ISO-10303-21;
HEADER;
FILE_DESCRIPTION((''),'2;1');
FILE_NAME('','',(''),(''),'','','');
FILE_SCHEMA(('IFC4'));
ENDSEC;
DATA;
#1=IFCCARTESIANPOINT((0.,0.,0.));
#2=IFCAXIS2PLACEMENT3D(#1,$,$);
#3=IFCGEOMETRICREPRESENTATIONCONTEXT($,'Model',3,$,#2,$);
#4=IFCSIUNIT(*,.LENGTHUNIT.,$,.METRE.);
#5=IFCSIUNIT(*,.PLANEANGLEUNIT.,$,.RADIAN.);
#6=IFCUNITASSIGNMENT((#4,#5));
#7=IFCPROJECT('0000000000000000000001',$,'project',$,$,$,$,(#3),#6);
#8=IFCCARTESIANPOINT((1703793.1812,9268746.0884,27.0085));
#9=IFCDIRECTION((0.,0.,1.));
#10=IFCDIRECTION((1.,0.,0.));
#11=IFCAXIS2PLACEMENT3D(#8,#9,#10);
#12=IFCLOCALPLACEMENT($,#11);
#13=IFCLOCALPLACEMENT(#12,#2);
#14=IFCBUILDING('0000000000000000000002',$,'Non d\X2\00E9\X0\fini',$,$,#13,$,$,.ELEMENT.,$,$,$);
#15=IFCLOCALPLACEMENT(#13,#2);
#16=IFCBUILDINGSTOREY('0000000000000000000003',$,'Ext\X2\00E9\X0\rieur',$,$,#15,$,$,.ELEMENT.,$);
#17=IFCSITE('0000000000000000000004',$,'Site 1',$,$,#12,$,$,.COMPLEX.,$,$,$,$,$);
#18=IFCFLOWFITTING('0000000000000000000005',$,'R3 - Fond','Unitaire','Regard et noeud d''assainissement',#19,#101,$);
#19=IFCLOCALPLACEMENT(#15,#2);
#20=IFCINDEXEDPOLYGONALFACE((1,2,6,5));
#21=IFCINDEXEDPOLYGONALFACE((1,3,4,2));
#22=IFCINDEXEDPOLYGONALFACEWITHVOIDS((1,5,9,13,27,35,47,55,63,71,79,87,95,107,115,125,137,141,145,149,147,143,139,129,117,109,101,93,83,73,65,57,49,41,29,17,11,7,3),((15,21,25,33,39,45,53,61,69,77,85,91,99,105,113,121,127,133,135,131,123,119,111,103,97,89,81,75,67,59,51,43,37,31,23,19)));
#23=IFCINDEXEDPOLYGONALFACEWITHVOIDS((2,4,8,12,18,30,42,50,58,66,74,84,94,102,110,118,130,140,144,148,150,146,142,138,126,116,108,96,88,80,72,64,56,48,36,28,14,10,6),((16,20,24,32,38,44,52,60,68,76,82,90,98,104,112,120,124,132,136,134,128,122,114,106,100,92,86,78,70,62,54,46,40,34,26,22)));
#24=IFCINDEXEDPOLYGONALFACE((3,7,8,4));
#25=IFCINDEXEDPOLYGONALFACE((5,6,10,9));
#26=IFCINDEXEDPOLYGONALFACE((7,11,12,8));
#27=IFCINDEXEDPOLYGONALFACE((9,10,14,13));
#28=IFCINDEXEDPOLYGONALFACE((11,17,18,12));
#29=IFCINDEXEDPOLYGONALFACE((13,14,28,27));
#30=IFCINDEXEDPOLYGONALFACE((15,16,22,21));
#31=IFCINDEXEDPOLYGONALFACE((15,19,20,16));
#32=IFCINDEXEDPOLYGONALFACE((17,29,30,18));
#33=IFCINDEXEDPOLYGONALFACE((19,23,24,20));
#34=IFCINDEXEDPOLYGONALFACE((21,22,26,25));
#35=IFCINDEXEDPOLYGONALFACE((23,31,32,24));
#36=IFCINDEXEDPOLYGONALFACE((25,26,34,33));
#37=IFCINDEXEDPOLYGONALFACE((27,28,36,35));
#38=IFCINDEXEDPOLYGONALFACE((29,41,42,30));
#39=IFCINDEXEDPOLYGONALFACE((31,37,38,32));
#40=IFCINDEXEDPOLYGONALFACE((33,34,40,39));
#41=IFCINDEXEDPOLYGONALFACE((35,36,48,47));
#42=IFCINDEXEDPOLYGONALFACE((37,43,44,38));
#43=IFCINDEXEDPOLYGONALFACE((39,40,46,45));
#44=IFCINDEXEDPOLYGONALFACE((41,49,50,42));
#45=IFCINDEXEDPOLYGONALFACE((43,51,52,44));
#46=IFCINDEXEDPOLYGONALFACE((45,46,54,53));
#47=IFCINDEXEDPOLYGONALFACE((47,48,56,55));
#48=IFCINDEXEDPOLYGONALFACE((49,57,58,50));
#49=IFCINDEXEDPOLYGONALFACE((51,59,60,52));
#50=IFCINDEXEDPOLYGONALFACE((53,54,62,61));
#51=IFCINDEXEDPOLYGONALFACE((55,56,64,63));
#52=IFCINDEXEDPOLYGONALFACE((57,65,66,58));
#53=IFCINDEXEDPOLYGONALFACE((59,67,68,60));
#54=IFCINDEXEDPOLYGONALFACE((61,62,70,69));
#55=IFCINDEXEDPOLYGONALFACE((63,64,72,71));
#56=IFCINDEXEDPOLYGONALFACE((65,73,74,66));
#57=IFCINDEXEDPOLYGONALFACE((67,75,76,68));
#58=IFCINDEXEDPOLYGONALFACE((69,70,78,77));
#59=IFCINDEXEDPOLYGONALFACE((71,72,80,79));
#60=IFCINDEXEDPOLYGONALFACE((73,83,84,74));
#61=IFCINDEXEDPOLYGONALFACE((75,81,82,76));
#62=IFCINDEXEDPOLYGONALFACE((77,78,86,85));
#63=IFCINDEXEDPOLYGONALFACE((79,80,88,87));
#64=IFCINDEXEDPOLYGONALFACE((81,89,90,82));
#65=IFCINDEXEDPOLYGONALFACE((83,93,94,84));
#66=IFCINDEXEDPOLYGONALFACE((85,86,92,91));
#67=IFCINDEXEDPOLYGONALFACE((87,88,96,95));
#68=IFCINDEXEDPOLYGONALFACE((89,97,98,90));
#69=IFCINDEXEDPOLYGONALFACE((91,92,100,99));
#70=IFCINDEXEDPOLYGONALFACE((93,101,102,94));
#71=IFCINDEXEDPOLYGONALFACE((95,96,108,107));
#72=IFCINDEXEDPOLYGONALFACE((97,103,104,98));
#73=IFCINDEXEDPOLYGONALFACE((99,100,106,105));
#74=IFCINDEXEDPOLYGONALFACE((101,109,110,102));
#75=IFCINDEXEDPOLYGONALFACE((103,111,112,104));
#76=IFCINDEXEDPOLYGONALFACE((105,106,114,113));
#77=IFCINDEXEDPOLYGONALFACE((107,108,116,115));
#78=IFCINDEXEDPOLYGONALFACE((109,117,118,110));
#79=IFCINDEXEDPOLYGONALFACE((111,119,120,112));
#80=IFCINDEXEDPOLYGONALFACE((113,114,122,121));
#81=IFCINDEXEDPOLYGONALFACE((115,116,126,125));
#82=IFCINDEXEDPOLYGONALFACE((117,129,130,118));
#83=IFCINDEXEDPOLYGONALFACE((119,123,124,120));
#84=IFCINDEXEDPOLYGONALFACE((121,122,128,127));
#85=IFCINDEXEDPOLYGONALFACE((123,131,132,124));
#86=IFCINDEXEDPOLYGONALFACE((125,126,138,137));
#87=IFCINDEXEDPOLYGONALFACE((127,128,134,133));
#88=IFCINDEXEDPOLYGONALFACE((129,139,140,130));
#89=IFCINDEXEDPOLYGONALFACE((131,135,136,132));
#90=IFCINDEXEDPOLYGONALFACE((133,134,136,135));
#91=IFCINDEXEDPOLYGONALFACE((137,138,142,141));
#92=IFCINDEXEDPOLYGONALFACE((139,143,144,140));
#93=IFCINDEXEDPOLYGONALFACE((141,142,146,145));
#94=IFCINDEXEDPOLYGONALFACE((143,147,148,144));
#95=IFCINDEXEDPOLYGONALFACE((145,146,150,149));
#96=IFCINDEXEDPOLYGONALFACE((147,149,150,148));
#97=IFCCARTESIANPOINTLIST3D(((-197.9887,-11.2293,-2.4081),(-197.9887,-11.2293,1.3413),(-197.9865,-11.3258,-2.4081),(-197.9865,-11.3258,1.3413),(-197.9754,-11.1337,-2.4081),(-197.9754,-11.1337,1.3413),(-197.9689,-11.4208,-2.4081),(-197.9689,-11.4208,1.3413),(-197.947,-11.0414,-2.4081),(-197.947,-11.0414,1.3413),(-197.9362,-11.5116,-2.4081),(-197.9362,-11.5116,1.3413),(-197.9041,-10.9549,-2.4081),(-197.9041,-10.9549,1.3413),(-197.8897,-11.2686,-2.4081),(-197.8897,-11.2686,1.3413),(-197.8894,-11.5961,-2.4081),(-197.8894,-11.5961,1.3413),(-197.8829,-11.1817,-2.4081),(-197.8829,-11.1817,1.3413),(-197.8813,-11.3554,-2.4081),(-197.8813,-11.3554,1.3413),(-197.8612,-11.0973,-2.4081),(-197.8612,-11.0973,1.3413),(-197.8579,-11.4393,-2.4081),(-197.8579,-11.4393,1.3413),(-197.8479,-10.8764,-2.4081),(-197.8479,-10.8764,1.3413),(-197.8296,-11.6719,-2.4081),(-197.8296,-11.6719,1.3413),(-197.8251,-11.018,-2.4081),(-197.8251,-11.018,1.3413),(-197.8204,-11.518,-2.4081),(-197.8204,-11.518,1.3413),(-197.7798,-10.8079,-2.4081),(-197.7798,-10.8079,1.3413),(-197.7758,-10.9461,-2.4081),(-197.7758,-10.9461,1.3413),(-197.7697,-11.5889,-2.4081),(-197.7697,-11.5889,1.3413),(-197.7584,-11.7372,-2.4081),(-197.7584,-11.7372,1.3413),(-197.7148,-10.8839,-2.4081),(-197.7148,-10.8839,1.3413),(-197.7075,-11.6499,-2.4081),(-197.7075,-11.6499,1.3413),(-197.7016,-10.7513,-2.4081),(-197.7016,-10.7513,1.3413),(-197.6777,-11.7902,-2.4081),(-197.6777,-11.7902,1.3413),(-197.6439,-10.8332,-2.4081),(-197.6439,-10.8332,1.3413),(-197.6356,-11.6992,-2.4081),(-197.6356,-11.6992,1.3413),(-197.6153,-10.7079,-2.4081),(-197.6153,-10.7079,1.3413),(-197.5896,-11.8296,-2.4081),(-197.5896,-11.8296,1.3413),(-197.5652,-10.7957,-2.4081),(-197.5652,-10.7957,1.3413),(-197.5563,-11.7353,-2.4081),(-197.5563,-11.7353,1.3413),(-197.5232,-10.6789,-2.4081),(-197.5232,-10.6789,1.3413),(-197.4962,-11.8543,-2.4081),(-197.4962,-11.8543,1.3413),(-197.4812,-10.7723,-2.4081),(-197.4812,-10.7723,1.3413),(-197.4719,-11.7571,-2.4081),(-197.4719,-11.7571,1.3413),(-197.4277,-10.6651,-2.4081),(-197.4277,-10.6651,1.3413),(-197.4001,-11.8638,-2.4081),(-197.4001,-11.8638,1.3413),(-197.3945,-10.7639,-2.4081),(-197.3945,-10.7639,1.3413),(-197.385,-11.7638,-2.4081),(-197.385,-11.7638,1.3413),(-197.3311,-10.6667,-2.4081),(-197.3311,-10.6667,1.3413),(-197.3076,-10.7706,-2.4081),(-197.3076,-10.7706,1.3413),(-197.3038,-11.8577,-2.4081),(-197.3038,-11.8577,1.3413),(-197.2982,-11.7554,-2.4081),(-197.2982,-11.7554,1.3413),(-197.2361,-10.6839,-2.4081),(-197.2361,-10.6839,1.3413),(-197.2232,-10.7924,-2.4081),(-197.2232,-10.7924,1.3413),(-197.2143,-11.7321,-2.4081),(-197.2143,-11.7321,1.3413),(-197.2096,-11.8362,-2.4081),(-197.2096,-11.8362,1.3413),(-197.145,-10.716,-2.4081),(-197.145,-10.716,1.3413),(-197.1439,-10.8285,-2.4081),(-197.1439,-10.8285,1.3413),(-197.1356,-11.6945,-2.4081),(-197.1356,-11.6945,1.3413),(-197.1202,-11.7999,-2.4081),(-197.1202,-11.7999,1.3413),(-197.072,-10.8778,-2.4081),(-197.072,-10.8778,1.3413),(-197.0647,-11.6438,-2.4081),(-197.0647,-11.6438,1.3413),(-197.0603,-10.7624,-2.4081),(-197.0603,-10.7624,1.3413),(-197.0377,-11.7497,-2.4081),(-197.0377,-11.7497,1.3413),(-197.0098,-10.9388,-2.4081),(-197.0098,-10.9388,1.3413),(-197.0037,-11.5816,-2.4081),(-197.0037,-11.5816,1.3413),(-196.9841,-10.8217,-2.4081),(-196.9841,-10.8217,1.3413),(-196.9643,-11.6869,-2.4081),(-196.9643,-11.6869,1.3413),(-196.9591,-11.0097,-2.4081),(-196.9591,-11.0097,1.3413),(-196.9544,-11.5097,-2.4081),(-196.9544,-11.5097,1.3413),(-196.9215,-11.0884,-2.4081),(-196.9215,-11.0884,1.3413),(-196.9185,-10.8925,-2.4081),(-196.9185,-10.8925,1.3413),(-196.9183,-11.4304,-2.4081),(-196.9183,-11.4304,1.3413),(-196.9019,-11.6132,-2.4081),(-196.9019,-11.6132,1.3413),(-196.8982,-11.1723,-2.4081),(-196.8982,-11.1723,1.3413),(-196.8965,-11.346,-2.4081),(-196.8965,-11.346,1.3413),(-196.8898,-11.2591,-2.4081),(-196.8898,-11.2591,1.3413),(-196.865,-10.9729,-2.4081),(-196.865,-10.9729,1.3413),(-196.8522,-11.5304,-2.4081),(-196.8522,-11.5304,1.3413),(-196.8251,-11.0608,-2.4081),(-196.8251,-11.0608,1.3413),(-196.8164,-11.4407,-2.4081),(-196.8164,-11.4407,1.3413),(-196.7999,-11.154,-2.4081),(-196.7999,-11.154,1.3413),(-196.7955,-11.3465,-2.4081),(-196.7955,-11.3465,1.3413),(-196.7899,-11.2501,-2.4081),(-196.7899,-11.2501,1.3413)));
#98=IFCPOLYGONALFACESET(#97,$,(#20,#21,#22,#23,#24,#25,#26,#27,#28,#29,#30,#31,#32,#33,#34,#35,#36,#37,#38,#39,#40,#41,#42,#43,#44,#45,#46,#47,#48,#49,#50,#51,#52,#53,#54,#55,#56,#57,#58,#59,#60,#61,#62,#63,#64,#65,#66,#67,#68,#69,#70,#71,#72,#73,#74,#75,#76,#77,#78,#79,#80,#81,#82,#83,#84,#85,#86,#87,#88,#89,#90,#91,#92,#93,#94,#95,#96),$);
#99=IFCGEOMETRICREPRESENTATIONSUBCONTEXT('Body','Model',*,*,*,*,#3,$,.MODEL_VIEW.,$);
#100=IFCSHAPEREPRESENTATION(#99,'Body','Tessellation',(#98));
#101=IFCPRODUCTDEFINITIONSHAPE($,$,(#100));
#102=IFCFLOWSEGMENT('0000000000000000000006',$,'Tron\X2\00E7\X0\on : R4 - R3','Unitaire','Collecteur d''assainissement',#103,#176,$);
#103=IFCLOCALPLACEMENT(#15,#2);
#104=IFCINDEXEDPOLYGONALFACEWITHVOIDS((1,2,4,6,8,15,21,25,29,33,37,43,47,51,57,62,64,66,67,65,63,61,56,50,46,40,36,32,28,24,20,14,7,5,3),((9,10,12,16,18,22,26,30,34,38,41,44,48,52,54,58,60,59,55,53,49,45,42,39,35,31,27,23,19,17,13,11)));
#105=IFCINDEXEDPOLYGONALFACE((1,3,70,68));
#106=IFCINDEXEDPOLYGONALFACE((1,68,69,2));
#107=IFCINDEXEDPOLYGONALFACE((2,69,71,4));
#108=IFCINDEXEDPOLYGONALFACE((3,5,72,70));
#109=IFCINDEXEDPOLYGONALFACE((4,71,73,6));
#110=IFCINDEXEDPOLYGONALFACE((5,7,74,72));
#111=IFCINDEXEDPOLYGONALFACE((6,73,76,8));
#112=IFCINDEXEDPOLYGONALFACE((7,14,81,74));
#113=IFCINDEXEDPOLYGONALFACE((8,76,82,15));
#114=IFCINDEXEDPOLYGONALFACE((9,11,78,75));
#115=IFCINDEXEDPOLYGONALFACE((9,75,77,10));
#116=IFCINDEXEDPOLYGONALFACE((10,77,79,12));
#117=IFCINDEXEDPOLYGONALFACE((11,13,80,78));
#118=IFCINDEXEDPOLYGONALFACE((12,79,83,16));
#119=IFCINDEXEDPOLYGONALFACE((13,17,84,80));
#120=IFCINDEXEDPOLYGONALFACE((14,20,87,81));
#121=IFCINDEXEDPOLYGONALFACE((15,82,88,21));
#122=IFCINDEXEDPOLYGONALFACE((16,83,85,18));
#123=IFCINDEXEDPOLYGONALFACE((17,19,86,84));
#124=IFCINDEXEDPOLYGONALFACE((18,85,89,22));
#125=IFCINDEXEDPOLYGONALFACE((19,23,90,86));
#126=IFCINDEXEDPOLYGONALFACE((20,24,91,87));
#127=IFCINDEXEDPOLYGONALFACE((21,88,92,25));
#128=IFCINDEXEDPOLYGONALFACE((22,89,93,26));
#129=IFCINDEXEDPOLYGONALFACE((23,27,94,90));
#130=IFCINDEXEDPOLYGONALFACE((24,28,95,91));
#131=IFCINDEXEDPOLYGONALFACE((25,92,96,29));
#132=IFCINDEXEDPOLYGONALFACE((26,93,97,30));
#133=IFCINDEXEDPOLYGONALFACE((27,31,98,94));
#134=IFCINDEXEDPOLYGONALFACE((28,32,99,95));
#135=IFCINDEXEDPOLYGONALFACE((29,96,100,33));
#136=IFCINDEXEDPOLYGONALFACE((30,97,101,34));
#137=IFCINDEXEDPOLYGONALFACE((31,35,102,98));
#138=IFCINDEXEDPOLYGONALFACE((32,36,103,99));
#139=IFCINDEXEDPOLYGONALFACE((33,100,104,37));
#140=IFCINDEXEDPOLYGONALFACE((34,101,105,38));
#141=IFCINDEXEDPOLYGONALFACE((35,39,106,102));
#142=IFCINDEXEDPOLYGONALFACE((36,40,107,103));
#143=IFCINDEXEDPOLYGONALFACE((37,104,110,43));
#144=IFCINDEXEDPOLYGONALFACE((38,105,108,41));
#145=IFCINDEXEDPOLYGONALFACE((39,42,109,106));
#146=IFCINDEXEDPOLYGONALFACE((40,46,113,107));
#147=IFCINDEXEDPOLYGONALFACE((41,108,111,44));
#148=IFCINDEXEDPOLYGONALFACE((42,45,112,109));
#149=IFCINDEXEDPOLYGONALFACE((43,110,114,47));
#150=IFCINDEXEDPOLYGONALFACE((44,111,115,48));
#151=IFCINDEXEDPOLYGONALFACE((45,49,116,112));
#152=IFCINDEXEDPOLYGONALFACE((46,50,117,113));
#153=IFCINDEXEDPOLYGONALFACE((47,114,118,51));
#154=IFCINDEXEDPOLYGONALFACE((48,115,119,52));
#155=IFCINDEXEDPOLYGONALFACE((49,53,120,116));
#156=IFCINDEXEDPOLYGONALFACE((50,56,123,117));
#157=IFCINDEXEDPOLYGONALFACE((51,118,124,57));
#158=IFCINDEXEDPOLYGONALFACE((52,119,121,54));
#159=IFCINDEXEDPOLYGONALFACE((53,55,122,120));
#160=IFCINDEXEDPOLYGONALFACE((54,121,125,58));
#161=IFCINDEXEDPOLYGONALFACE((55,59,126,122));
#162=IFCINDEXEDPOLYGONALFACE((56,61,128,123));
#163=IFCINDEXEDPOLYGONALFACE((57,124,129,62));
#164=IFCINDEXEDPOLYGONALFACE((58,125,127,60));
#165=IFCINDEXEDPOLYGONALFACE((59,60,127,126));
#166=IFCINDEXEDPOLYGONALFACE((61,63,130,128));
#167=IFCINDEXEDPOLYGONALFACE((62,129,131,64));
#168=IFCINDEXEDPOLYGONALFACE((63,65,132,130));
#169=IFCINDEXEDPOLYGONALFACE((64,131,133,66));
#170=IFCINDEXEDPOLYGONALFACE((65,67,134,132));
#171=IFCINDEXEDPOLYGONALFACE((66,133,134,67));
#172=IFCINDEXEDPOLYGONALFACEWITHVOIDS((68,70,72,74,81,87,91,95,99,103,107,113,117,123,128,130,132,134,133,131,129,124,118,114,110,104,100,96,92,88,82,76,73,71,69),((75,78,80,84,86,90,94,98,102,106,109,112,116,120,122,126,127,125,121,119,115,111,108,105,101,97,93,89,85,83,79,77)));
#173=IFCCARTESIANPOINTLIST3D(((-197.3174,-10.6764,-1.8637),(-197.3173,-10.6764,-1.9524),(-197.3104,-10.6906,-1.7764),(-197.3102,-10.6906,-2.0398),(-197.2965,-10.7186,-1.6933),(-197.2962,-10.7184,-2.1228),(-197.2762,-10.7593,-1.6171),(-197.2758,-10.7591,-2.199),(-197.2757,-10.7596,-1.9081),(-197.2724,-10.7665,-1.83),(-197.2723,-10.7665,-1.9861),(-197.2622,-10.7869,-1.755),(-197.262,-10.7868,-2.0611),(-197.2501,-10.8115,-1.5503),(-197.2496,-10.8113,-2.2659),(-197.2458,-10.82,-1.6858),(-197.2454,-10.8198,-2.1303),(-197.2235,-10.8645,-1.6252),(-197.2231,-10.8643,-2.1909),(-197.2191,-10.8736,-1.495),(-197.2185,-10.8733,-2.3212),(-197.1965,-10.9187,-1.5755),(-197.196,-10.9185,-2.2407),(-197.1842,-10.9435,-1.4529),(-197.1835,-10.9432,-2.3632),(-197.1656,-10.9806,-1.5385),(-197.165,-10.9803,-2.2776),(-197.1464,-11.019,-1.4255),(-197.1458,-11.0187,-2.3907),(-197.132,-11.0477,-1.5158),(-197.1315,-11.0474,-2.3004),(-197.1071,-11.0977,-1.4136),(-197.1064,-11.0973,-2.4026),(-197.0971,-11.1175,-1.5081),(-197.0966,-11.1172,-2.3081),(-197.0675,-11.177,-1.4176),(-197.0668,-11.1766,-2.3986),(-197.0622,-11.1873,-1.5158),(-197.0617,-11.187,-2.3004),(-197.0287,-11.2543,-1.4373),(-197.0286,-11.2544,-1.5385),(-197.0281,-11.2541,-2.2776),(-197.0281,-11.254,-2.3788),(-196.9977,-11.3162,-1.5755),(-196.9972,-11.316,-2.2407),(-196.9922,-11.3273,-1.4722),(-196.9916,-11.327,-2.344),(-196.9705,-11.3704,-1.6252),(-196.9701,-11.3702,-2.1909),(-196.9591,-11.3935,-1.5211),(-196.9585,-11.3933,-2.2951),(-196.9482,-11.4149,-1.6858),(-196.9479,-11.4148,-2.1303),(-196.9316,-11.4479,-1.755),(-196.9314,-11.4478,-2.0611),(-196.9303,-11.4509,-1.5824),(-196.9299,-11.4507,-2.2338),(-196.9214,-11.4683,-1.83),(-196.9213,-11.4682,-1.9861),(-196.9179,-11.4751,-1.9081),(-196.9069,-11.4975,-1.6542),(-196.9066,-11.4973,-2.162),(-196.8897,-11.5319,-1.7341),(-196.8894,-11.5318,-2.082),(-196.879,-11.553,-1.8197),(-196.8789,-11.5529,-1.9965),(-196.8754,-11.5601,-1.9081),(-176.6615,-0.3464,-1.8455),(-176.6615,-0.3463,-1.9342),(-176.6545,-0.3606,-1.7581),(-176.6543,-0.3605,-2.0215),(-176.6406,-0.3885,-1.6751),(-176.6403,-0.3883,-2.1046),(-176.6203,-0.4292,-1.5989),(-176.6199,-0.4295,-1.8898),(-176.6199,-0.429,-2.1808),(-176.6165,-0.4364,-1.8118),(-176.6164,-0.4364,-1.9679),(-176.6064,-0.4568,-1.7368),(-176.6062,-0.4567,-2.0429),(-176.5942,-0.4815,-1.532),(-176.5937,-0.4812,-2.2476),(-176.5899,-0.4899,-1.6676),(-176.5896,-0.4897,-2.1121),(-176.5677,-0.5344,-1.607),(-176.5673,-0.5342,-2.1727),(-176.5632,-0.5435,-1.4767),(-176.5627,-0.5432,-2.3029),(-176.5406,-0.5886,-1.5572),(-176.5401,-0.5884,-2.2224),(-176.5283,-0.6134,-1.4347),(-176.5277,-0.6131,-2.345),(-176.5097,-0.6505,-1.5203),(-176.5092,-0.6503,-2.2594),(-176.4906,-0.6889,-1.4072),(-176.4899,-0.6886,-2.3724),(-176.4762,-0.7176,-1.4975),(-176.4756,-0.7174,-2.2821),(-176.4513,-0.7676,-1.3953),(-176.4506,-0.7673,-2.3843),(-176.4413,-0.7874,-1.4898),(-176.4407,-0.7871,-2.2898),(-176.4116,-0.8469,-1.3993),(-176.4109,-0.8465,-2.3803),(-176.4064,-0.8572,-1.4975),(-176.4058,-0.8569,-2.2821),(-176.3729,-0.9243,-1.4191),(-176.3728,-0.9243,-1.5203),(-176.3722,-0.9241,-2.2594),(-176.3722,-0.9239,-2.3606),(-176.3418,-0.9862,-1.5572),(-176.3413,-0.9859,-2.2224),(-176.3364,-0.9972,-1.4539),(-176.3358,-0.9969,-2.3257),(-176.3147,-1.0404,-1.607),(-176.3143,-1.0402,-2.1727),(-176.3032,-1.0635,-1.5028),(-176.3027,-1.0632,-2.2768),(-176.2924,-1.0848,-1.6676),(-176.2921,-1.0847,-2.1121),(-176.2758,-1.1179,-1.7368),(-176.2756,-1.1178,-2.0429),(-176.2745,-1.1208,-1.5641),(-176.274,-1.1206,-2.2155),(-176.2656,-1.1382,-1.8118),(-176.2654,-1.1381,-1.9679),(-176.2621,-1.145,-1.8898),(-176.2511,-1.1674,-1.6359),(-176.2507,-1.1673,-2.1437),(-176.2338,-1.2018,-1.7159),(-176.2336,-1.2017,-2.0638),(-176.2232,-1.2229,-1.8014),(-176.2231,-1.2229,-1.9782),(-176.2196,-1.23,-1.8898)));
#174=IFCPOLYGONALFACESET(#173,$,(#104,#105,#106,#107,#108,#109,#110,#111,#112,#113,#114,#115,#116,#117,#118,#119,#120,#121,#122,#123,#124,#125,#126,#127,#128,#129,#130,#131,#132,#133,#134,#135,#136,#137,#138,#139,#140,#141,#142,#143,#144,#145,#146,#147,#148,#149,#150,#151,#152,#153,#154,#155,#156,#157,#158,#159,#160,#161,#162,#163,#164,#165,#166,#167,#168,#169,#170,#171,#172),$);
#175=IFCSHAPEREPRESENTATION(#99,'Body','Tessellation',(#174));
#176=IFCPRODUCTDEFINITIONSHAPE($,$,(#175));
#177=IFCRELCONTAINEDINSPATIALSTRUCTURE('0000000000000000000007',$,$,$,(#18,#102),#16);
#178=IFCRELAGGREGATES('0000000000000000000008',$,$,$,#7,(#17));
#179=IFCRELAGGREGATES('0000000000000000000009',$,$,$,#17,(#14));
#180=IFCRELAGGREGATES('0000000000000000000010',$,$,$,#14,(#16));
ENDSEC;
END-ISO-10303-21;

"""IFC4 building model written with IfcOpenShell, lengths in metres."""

from ifc_helpers import new_model, si_unit, frame, origin, origin_2d, place, context, subcontext, project, spatial, hollow_circle, extrude, element, save


model = new_model("IFC4")

# Units and contexts
model_context = context("Model", 3, world=origin())
body_context = subcontext(model_context, "Body", "Model", "MODEL_VIEW")
ifc_project = project(units=[si_unit("LENGTHUNIT", "METRE"), si_unit("PLANEANGLEUNIT", "RADIAN")], contexts=[model_context])

# Site, building, storey
site_placement = place(None, frame((1703793.1812, 9268746.0884, 27.0085), z_axis=(0.0, 0.0, 1.0), x_axis=(1.0, 0.0, 0.0)))
site = spatial("IfcSite", under=ifc_project, at=site_placement, Name="Site 1", CompositionType="COMPLEX")
building_placement = place(site_placement, origin())
building = spatial("IfcBuilding", under=site, at=building_placement, Name="Non défini", CompositionType="ELEMENT")
storey_placement = place(building_placement, origin())
storey = spatial("IfcBuildingStorey", under=building, at=storey_placement, Name="Extérieur", CompositionType="ELEMENT")

# Flow fitting
flow_fitting_1_placement = place(storey_placement, origin())
element("IfcFlowFitting", 1, at=flow_fitting_1_placement, inside=storey, Name="R3 - Fond", Description="Unitaire", ObjectType="Regard et noeud d'assainissement", context=body_context, shape_type="SweptSolid", body=[
    extrude(hollow_circle(Radius=0.6, WallThickness=0.1, at=origin_2d()), frame((-197.3897, -11.2639, -2.4081), z_axis=(0.0, 0.0, 1.0), x_axis=(0.983109, 0.183021, 0.0)), (0.0, 0.0, 1.0), 3.7494),
])

# Flow segment
flow_segment_1_placement = place(storey_placement, origin())
element("IfcFlowSegment", 2, at=flow_segment_1_placement, inside=storey, Name="Tronçon : R4 - R3", Description="Unitaire", ObjectType="Collecteur d'assainissement", context=body_context, shape_type="SweptSolid", body=[
    extrude(hollow_circle(Radius=0.495, WallThickness=0.095, at=origin_2d()), frame((-176.441, -0.7873, -1.8898), z_axis=(-0.89439, -0.447288, -0.00079), x_axis=(0.447288, -0.89439, 0.0)), (0.0, 0.0, 1.0), 23.0949),
])

save(model, "model.ifc")
